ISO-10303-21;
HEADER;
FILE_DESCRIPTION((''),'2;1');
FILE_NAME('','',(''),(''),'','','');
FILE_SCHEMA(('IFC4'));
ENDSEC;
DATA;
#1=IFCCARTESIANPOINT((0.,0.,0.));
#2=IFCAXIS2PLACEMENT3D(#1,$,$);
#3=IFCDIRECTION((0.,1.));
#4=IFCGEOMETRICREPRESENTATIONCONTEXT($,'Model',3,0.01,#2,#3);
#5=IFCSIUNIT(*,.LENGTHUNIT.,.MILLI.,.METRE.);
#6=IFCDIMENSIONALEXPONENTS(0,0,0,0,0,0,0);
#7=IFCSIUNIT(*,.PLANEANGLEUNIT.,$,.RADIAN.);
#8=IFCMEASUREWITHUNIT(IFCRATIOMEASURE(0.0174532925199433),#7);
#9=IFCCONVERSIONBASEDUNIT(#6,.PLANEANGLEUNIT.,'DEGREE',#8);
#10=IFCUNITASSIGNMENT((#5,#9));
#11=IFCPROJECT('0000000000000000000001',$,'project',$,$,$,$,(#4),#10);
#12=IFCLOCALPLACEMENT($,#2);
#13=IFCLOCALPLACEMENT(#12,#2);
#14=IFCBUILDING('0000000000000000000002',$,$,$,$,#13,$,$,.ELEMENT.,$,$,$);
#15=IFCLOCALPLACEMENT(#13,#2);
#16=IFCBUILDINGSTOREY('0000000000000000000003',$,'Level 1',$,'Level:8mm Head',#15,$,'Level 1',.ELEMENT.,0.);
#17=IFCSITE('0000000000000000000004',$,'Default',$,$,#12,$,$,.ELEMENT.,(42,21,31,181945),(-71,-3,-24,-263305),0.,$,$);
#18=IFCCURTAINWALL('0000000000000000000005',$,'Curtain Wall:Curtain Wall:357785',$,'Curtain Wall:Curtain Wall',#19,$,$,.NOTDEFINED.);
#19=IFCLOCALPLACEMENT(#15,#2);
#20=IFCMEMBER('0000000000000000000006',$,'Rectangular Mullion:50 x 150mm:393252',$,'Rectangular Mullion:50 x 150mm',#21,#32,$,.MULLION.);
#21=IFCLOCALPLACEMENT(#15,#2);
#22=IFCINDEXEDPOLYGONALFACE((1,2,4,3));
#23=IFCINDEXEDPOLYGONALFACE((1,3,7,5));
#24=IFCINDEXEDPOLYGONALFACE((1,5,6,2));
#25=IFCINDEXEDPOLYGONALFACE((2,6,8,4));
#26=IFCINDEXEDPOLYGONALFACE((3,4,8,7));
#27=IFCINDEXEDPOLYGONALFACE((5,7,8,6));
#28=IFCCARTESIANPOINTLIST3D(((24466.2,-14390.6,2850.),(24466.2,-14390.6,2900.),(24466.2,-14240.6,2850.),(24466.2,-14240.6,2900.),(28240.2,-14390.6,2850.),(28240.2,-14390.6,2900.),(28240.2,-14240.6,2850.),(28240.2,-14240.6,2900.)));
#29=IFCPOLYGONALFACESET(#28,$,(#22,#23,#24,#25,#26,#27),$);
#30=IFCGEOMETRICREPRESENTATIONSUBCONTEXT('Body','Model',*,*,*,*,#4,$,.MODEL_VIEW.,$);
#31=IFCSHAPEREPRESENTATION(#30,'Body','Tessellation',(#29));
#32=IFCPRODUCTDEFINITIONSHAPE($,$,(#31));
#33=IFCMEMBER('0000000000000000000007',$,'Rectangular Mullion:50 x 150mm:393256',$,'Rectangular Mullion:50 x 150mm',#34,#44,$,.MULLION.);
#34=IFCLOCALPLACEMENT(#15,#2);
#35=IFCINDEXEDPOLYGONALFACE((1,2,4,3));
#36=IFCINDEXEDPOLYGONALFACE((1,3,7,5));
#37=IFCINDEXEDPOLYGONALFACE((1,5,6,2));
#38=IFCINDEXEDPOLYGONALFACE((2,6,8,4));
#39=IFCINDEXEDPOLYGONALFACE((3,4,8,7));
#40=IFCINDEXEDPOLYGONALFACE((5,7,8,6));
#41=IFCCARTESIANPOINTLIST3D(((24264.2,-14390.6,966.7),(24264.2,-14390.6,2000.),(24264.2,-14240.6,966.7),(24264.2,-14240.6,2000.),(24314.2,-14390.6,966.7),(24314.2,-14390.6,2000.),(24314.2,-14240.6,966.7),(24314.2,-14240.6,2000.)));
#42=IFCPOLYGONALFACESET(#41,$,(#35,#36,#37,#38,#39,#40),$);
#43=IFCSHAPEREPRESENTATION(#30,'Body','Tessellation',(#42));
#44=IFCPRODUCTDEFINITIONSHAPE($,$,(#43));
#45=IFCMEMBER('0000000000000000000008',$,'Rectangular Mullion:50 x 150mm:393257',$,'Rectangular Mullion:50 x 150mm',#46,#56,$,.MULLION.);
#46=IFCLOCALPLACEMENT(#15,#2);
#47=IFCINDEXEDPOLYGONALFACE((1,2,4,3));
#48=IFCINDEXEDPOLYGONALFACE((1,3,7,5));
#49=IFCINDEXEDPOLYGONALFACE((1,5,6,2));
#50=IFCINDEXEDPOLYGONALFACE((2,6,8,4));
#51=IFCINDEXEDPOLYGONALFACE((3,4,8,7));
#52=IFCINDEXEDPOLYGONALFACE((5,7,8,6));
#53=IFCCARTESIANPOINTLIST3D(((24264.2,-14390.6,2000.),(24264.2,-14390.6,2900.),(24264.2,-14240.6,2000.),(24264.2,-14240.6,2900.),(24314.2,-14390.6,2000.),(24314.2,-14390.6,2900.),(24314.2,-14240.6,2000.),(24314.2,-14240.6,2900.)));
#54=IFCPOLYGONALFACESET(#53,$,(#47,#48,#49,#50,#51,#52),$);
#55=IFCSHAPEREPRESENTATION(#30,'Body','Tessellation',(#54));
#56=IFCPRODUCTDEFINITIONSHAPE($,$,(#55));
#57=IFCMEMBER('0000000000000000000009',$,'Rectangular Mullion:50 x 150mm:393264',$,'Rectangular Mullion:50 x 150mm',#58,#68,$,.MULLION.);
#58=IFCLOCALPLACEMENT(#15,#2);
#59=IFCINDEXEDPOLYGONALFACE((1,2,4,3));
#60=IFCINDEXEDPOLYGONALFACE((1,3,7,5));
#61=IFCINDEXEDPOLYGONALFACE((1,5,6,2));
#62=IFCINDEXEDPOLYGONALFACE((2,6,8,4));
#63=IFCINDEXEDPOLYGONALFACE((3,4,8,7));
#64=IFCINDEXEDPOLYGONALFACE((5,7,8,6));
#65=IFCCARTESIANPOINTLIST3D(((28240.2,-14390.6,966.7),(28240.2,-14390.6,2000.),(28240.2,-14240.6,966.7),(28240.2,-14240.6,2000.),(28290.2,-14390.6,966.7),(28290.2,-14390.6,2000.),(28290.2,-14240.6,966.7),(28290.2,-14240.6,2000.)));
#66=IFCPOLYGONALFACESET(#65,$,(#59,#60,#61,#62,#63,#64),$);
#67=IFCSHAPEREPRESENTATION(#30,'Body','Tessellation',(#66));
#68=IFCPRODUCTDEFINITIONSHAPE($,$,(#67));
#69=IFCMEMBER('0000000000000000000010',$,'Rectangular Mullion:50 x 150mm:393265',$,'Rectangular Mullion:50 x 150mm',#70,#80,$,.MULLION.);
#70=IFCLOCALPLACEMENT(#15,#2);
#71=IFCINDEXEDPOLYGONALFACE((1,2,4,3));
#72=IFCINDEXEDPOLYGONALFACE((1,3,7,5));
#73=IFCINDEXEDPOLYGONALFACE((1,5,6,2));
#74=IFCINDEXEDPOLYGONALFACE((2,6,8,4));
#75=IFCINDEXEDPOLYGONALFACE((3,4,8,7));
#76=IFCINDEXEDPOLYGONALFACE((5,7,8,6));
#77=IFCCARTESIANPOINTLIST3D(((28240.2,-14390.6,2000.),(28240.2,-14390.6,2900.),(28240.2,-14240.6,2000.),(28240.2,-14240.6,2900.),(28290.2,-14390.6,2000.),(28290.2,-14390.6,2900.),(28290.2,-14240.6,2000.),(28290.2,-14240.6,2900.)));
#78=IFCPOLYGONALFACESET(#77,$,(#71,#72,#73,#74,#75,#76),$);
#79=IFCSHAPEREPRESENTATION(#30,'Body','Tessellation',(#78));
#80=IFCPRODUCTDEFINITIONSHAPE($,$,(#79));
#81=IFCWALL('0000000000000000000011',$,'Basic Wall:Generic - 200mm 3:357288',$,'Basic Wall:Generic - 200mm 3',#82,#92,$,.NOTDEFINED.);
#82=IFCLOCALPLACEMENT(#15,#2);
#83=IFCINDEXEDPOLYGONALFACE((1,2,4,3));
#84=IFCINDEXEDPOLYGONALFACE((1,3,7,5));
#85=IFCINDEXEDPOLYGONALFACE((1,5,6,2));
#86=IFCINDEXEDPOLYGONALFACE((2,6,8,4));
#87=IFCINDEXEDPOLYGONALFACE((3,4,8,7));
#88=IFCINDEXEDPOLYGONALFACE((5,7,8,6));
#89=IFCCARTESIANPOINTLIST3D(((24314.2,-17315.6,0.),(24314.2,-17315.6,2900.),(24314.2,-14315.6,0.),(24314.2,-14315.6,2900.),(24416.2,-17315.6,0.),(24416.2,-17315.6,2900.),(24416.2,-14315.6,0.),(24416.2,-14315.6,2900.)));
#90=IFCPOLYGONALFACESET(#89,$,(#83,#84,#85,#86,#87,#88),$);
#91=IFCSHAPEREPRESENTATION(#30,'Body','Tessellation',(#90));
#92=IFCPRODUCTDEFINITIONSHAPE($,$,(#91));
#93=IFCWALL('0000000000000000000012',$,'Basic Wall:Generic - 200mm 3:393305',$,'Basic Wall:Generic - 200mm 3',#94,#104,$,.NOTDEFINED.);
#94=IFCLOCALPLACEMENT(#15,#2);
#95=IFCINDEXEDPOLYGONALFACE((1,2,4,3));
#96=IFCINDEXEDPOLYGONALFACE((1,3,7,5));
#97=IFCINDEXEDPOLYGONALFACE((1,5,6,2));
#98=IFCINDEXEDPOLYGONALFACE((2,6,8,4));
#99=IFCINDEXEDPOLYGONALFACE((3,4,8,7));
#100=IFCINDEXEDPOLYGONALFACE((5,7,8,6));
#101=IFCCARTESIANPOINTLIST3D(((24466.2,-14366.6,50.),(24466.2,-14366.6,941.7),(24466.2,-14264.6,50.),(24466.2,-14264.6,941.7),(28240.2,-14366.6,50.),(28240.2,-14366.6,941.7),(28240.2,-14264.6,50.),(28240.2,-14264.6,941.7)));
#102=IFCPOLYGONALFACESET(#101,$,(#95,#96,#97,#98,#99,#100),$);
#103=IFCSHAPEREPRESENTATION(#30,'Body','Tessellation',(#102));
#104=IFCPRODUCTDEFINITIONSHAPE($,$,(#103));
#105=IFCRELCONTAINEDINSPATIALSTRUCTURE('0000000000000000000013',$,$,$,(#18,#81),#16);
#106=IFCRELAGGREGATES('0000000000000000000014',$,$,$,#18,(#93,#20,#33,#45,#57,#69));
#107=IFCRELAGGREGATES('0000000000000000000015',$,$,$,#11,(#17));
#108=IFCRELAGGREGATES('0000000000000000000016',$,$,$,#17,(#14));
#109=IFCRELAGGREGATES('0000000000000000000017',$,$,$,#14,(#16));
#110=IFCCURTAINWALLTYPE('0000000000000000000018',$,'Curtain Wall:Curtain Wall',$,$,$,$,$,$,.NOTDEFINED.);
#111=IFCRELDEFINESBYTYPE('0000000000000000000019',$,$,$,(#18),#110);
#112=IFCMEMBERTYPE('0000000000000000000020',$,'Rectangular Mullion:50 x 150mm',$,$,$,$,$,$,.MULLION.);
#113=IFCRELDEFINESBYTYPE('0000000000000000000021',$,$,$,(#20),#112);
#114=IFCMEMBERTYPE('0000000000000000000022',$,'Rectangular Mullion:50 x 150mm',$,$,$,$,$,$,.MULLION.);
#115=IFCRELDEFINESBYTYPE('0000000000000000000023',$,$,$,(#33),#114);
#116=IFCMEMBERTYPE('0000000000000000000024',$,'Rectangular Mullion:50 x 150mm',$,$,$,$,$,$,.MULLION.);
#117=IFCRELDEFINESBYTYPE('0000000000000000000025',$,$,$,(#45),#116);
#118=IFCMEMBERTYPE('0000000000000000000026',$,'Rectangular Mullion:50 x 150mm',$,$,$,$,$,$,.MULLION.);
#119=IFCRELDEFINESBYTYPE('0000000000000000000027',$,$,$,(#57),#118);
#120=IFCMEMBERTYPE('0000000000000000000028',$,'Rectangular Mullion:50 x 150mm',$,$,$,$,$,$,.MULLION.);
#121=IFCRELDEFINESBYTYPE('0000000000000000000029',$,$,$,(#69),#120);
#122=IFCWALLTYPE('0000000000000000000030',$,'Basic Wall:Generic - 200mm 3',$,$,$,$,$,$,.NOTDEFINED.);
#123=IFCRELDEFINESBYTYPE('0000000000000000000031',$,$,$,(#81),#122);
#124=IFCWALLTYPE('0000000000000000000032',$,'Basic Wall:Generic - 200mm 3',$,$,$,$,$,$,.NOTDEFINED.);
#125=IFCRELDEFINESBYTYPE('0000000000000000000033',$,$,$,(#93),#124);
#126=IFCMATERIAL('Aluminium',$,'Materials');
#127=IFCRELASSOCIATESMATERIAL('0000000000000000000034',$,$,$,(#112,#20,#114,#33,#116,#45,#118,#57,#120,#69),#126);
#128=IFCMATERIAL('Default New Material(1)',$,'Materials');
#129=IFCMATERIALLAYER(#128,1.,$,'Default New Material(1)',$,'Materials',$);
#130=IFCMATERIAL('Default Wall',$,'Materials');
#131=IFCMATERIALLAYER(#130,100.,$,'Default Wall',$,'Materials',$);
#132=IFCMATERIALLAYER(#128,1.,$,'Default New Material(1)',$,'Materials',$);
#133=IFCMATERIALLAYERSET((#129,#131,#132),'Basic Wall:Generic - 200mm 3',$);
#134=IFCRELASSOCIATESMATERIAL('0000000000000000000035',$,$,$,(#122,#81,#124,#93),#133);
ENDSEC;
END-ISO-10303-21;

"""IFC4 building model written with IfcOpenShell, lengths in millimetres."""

from ifc_helpers import new_model, entity, si_unit, converted_unit, direction, frame, origin, place, context, subcontext, project, spatial, indexed_curve, outline, extrude, source, transform, mapped, material, layer, layer_set, type_object, type_shapes, element, aggregate, save


model = new_model("IFC4")

# Units and contexts
model_context = context("Model", 3, precision=0.01, world=origin(), true_north=direction((0.0, 1.0)))
body_context = subcontext(model_context, "Body", "Model", "MODEL_VIEW")
ifc_project = project(units=[si_unit("LENGTHUNIT", "METRE", prefix="MILLI"), converted_unit("PLANEANGLEUNIT", "DEGREE", entity("IfcRatioMeasure", 0.0174532925199433), si_unit("PLANEANGLEUNIT", "RADIAN"), dimensions=[0, 0, 0, 0, 0, 0, 0])], contexts=[model_context])

# Site, building, storey
site_placement = place(None, origin())
site = spatial("IfcSite", under=ifc_project, at=site_placement, Name="Default", CompositionType="ELEMENT", RefLatitude=(42, 21, 31, 181945), RefLongitude=(-71, -3, -24, -263305), RefElevation=0.0)
building_placement = place(site_placement, origin())
building = spatial("IfcBuilding", under=site, at=building_placement, CompositionType="ELEMENT")
storey_placement = place(building_placement, origin())
storey = spatial("IfcBuildingStorey", under=building, at=storey_placement, Name="Level 1", ObjectType="Level:8mm Head", LongName="Level 1", CompositionType="ELEMENT", Elevation=0.0)

# Curtain wall, members
ifc_material_1 = material(Name="Aluminium", Category="Materials")
curtain_wall_type_1 = type_object("IfcCurtainWallType", Name="Curtain Wall:Curtain Wall", PredefinedType="NOTDEFINED")
curtain_wall_1_placement = place(storey_placement, origin())
curtain_wall_1 = element("IfcCurtainWall", 1, at=curtain_wall_1_placement, inside=storey, type_object=curtain_wall_type_1, Name="Curtain Wall:Curtain Wall:357785", ObjectType="Curtain Wall:Curtain Wall", PredefinedType="NOTDEFINED")
member_type_1 = type_object("IfcMemberType", Name="Rectangular Mullion:50 x 150mm", PredefinedType="MULLION", material=ifc_material_1)
shared_shape_1 = source(origin(), body_context, "Body", "SweptSolid", [
    extrude(outline(indexed_curve([(-75.0, -25.0), (75.0, -25.0), (75.0, 25.0), (-75.0, 25.0), (-75.0, -25.0)], self_intersect=False)), frame((-25.0, 0.0, -3774.0), z_axis=(0.0, 0.0, 1.0), x_axis=(0.0, -1.0, 0.0)), (0.0, 0.0, 1.0), 3774.0),
])
type_shapes(member_type_1, [shared_shape_1])
member_1_placement = place(storey_placement, frame((28240.2, -14315.6, 2900.0), z_axis=(1.0, 0.0, 0.0), x_axis=(0.0, 0.0, 1.0)))
member_1 = element("IfcMember", 2, at=member_1_placement, type_object=member_type_1, material=ifc_material_1, Name="Rectangular Mullion:50 x 150mm:393252", ObjectType="Rectangular Mullion:50 x 150mm", PredefinedType="MULLION", context=body_context, shape_type="MappedRepresentation", body=[
    mapped(shared_shape_1, transform((0.0, 0.0, 0.0), scale=1.0)),
])
member_type_2 = type_object("IfcMemberType", Name="Rectangular Mullion:50 x 150mm", PredefinedType="MULLION", material=ifc_material_1)
shared_shape_2 = source(origin(), body_context, "Body", "SweptSolid", [
    extrude(outline(indexed_curve([(-75.0, -25.0), (75.0, -25.0), (75.0, 25.0), (-75.0, 25.0), (-75.0, -25.0)], self_intersect=False)), frame((-25.0, 0.0, -1033.3), z_axis=(0.0, 0.0, 1.0), x_axis=(0.0, -1.0, 0.0)), (0.0, 0.0, 1.0), 1033.3),
])
type_shapes(member_type_2, [shared_shape_2])
member_2_placement = place(storey_placement, frame((24314.2, -14315.6, 966.7), z_axis=(0.0, 0.0, -1.0), x_axis=(1.0, 0.0, 0.0)))
member_2 = element("IfcMember", 3, at=member_2_placement, type_object=member_type_2, material=ifc_material_1, Name="Rectangular Mullion:50 x 150mm:393256", ObjectType="Rectangular Mullion:50 x 150mm", PredefinedType="MULLION", context=body_context, shape_type="MappedRepresentation", body=[
    mapped(shared_shape_2, transform((0.0, 0.0, 0.0), scale=1.0)),
])
member_type_3 = type_object("IfcMemberType", Name="Rectangular Mullion:50 x 150mm", PredefinedType="MULLION", material=ifc_material_1)
shared_shape_3 = source(origin(), body_context, "Body", "SweptSolid", [
    extrude(outline(indexed_curve([(-75.0, -25.0), (75.0, -25.0), (75.0, 25.0), (-75.0, 25.0), (-75.0, -25.0)], self_intersect=False)), frame((-25.0, 0.0, -900.0), z_axis=(0.0, 0.0, 1.0), x_axis=(0.0, -1.0, 0.0)), (0.0, 0.0, 1.0), 900.0),
])
type_shapes(member_type_3, [shared_shape_3])
member_3_placement = place(storey_placement, frame((24314.2, -14315.6, 2000.0), z_axis=(0.0, 0.0, -1.0), x_axis=(1.0, 0.0, 0.0)))
member_3 = element("IfcMember", 4, at=member_3_placement, type_object=member_type_3, material=ifc_material_1, Name="Rectangular Mullion:50 x 150mm:393257", ObjectType="Rectangular Mullion:50 x 150mm", PredefinedType="MULLION", context=body_context, shape_type="MappedRepresentation", body=[
    mapped(shared_shape_3, transform((0.0, 0.0, 0.0), scale=1.0)),
])
member_type_4 = type_object("IfcMemberType", Name="Rectangular Mullion:50 x 150mm", PredefinedType="MULLION", material=ifc_material_1)
shared_shape_4 = source(origin(), body_context, "Body", "SweptSolid", [
    extrude(outline(indexed_curve([(-75.0, -25.0), (75.0, -25.0), (75.0, 25.0), (-75.0, 25.0), (-75.0, -25.0)], self_intersect=False)), frame((0.0, 0.0, -1033.3), z_axis=(0.0, 0.0, 1.0), x_axis=(0.0, -1.0, 0.0)), (0.0, 0.0, 1.0), 1033.3),
])
type_shapes(member_type_4, [shared_shape_4])
member_4_placement = place(storey_placement, frame((28265.2, -14315.6, 966.7), z_axis=(0.0, 0.0, -1.0), x_axis=(1.0, 0.0, 0.0)))
member_4 = element("IfcMember", 5, at=member_4_placement, type_object=member_type_4, material=ifc_material_1, Name="Rectangular Mullion:50 x 150mm:393264", ObjectType="Rectangular Mullion:50 x 150mm", PredefinedType="MULLION", context=body_context, shape_type="MappedRepresentation", body=[
    mapped(shared_shape_4, transform((0.0, 0.0, 0.0), scale=1.0)),
])
member_type_5 = type_object("IfcMemberType", Name="Rectangular Mullion:50 x 150mm", PredefinedType="MULLION", material=ifc_material_1)
shared_shape_5 = source(origin(), body_context, "Body", "SweptSolid", [
    extrude(outline(indexed_curve([(-75.0, -25.0), (75.0, -25.0), (75.0, 25.0), (-75.0, 25.0), (-75.0, -25.0)], self_intersect=False)), frame((0.0, 0.0, -900.0), z_axis=(0.0, 0.0, 1.0), x_axis=(0.0, -1.0, 0.0)), (0.0, 0.0, 1.0), 900.0),
])
type_shapes(member_type_5, [shared_shape_5])
member_5_placement = place(storey_placement, frame((28265.2, -14315.6, 2000.0), z_axis=(0.0, 0.0, -1.0), x_axis=(1.0, 0.0, 0.0)))
member_5 = element("IfcMember", 6, at=member_5_placement, type_object=member_type_5, material=ifc_material_1, Name="Rectangular Mullion:50 x 150mm:393265", ObjectType="Rectangular Mullion:50 x 150mm", PredefinedType="MULLION", context=body_context, shape_type="MappedRepresentation", body=[
    mapped(shared_shape_5, transform((0.0, 0.0, 0.0), scale=1.0)),
])

# Walls
ifc_material_2 = material(Name="Default New Material(1)", Category="Materials")
ifc_layer_1 = layer(ifc_material_2, 1.0, Name="Default New Material(1)", Category="Materials")
ifc_material_3 = material(Name="Default Wall", Category="Materials")
ifc_layer_2 = layer(ifc_material_3, 100.0, Name="Default Wall", Category="Materials")
ifc_layer_3 = layer(ifc_material_2, 1.0, Name="Default New Material(1)", Category="Materials")
ifc_layer_set = layer_set([ifc_layer_1, ifc_layer_2, ifc_layer_3], Name="Basic Wall:Generic - 200mm 3")
wall_type_1 = type_object("IfcWallType", Name="Basic Wall:Generic - 200mm 3", PredefinedType="NOTDEFINED", material=ifc_layer_set)
wall_1_placement = place(storey_placement, frame((24365.2, -17315.6, 0.0), z_axis=(0.0, 0.0, 1.0), x_axis=(0.0, 1.0, 0.0)))
element("IfcWall", 7, at=wall_1_placement, inside=storey, type_object=wall_type_1, material=ifc_layer_set, Name="Basic Wall:Generic - 200mm 3:357288", ObjectType="Basic Wall:Generic - 200mm 3", PredefinedType="NOTDEFINED", context=body_context, shape_type="SweptSolid", body=[
    extrude(outline(indexed_curve([(3000.0, 51.0), (0.0, 51.0), (0.0, -51.0), (3000.0, -51.0), (3000.0, 51.0)], self_intersect=False)), origin(), (0.0, 0.0, 1.0), 2900.0),
])
wall_type_2 = type_object("IfcWallType", Name="Basic Wall:Generic - 200mm 3", PredefinedType="NOTDEFINED", material=ifc_layer_set)
wall_2_placement = place(storey_placement, frame((24466.2, -14315.6, 50.0)))
wall_2 = element("IfcWall", 8, at=wall_2_placement, type_object=wall_type_2, material=ifc_layer_set, Name="Basic Wall:Generic - 200mm 3:393305", ObjectType="Basic Wall:Generic - 200mm 3", PredefinedType="NOTDEFINED", context=body_context, shape_type="SweptSolid", body=[
    extrude(outline(indexed_curve([(3774.0, 51.0), (0.0, 51.0), (0.0, -51.0), (3774.0, -51.0), (3774.0, 51.0)], self_intersect=False)), origin(), (0.0, 0.0, 1.0), 891.7),
])
aggregate(curtain_wall_1, [wall_2, member_1, member_2, member_3, member_4, member_5])

save(model, "model.ifc")
